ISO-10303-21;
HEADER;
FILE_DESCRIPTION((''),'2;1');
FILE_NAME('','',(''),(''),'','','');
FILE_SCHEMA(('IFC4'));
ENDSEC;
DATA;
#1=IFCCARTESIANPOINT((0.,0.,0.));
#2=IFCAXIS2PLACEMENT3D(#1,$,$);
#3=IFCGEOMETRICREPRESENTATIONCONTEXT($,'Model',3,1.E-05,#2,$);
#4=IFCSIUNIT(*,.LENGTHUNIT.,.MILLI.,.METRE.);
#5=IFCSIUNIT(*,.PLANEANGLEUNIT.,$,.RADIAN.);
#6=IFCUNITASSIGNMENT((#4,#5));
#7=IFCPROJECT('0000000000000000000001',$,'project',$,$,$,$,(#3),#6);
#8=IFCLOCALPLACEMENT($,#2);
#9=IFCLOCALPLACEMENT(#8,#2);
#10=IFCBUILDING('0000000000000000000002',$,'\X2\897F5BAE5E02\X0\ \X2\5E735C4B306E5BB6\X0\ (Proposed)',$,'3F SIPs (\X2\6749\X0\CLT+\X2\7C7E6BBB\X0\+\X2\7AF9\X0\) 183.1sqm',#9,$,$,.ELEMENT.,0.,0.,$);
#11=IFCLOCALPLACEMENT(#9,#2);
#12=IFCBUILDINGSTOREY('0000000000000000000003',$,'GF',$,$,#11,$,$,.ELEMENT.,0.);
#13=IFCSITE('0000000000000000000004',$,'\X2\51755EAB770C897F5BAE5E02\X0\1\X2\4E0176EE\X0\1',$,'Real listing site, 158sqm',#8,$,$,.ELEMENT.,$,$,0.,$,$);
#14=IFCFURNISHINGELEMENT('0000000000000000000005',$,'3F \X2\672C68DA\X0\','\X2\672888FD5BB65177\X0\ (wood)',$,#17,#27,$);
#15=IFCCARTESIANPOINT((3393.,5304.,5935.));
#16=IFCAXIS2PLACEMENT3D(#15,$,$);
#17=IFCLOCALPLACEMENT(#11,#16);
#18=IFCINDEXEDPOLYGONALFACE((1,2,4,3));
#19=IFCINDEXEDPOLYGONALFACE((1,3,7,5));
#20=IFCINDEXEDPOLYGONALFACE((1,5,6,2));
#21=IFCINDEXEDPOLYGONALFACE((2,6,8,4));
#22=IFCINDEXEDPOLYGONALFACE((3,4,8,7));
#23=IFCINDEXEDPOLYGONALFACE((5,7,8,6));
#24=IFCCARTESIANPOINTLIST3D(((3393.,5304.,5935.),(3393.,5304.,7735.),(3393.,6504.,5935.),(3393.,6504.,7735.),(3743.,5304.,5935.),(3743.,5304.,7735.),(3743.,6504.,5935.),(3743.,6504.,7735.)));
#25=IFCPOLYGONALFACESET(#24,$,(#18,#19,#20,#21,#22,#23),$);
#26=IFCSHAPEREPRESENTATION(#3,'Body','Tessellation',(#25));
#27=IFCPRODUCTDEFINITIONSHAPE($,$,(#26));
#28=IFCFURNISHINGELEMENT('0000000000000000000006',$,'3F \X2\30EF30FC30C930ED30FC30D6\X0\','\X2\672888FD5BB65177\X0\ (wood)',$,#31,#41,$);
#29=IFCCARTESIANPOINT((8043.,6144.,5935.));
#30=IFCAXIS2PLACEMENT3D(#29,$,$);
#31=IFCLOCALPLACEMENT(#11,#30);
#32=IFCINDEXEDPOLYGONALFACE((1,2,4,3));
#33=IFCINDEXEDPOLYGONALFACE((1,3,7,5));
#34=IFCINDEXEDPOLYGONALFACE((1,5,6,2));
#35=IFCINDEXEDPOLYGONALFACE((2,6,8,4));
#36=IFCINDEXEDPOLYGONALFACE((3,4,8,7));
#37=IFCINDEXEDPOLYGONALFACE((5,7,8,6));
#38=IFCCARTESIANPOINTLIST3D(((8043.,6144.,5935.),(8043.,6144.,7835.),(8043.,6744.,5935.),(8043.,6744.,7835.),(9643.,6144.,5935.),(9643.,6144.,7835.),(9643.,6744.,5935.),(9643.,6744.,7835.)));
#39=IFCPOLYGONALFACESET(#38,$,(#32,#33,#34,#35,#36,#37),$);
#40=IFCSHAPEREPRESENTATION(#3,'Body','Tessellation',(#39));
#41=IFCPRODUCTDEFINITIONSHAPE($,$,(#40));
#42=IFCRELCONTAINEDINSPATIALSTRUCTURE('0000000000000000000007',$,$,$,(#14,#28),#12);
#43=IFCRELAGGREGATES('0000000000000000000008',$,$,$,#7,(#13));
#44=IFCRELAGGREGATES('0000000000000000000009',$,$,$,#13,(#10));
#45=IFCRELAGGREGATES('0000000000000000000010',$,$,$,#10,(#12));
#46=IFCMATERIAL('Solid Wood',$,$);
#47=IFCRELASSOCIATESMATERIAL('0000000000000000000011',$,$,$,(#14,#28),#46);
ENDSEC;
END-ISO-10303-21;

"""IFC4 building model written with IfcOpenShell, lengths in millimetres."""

from ifc_helpers import new_model, si_unit, frame, frame_2d, origin, place, context, project, spatial, rectangle, extrude, material, element, save


model = new_model("IFC4")

# Units and contexts
model_context = context("Model", 3, precision=1e-05, world=origin())
ifc_project = project(units=[si_unit("LENGTHUNIT", "METRE", prefix="MILLI"), si_unit("PLANEANGLEUNIT", "RADIAN")], contexts=[model_context])

# Site, building, storey
site_placement = place(None, origin())
site = spatial("IfcSite", under=ifc_project, at=site_placement, Name="兵庫県西宮市1丁目1", ObjectType="Real listing site, 158sqm", CompositionType="ELEMENT", RefElevation=0.0)
building_placement = place(site_placement, origin())
building = spatial("IfcBuilding", under=site, at=building_placement, Name="西宮市 平屋の家 (Proposed)", ObjectType="3F SIPs (杉CLT+籾殻+竹) 183.1sqm", CompositionType="ELEMENT", ElevationOfRefHeight=0.0, ElevationOfTerrain=0.0)
storey_placement = place(building_placement, origin())
storey = spatial("IfcBuildingStorey", under=building, at=storey_placement, Name="GF", CompositionType="ELEMENT", Elevation=0.0)

# Shared definitions
ifc_material_1 = material(Name="Solid Wood")

# Furnishing elements
furnishing_1_placement = place(storey_placement, frame((3393.0, 5304.0, 5935.0)))
element("IfcFurnishingElement", 1, at=furnishing_1_placement, inside=storey, material=ifc_material_1, Name="3F 本棚", Description="木製家具 (wood)", context=model_context, shape_type="SweptSolid", body=[
    extrude(rectangle(XDim=350.0, YDim=1200.0, at=frame_2d((175.0, 600.0))), frame((3393.0, 5304.0, 5935.0)), (0.0, 0.0, 1.0), 1800.0),
])
furnishing_2_placement = place(storey_placement, frame((8043.0, 6144.0, 5935.0)))
element("IfcFurnishingElement", 2, at=furnishing_2_placement, inside=storey, material=ifc_material_1, Name="3F ワードローブ", Description="木製家具 (wood)", context=model_context, shape_type="SweptSolid", body=[
    extrude(rectangle(XDim=1600.0, YDim=600.0, at=frame_2d((800.0, 300.0))), frame((8043.0, 6144.0, 5935.0)), (0.0, 0.0, 1.0), 1900.0),
])

save(model, "model.ifc")
